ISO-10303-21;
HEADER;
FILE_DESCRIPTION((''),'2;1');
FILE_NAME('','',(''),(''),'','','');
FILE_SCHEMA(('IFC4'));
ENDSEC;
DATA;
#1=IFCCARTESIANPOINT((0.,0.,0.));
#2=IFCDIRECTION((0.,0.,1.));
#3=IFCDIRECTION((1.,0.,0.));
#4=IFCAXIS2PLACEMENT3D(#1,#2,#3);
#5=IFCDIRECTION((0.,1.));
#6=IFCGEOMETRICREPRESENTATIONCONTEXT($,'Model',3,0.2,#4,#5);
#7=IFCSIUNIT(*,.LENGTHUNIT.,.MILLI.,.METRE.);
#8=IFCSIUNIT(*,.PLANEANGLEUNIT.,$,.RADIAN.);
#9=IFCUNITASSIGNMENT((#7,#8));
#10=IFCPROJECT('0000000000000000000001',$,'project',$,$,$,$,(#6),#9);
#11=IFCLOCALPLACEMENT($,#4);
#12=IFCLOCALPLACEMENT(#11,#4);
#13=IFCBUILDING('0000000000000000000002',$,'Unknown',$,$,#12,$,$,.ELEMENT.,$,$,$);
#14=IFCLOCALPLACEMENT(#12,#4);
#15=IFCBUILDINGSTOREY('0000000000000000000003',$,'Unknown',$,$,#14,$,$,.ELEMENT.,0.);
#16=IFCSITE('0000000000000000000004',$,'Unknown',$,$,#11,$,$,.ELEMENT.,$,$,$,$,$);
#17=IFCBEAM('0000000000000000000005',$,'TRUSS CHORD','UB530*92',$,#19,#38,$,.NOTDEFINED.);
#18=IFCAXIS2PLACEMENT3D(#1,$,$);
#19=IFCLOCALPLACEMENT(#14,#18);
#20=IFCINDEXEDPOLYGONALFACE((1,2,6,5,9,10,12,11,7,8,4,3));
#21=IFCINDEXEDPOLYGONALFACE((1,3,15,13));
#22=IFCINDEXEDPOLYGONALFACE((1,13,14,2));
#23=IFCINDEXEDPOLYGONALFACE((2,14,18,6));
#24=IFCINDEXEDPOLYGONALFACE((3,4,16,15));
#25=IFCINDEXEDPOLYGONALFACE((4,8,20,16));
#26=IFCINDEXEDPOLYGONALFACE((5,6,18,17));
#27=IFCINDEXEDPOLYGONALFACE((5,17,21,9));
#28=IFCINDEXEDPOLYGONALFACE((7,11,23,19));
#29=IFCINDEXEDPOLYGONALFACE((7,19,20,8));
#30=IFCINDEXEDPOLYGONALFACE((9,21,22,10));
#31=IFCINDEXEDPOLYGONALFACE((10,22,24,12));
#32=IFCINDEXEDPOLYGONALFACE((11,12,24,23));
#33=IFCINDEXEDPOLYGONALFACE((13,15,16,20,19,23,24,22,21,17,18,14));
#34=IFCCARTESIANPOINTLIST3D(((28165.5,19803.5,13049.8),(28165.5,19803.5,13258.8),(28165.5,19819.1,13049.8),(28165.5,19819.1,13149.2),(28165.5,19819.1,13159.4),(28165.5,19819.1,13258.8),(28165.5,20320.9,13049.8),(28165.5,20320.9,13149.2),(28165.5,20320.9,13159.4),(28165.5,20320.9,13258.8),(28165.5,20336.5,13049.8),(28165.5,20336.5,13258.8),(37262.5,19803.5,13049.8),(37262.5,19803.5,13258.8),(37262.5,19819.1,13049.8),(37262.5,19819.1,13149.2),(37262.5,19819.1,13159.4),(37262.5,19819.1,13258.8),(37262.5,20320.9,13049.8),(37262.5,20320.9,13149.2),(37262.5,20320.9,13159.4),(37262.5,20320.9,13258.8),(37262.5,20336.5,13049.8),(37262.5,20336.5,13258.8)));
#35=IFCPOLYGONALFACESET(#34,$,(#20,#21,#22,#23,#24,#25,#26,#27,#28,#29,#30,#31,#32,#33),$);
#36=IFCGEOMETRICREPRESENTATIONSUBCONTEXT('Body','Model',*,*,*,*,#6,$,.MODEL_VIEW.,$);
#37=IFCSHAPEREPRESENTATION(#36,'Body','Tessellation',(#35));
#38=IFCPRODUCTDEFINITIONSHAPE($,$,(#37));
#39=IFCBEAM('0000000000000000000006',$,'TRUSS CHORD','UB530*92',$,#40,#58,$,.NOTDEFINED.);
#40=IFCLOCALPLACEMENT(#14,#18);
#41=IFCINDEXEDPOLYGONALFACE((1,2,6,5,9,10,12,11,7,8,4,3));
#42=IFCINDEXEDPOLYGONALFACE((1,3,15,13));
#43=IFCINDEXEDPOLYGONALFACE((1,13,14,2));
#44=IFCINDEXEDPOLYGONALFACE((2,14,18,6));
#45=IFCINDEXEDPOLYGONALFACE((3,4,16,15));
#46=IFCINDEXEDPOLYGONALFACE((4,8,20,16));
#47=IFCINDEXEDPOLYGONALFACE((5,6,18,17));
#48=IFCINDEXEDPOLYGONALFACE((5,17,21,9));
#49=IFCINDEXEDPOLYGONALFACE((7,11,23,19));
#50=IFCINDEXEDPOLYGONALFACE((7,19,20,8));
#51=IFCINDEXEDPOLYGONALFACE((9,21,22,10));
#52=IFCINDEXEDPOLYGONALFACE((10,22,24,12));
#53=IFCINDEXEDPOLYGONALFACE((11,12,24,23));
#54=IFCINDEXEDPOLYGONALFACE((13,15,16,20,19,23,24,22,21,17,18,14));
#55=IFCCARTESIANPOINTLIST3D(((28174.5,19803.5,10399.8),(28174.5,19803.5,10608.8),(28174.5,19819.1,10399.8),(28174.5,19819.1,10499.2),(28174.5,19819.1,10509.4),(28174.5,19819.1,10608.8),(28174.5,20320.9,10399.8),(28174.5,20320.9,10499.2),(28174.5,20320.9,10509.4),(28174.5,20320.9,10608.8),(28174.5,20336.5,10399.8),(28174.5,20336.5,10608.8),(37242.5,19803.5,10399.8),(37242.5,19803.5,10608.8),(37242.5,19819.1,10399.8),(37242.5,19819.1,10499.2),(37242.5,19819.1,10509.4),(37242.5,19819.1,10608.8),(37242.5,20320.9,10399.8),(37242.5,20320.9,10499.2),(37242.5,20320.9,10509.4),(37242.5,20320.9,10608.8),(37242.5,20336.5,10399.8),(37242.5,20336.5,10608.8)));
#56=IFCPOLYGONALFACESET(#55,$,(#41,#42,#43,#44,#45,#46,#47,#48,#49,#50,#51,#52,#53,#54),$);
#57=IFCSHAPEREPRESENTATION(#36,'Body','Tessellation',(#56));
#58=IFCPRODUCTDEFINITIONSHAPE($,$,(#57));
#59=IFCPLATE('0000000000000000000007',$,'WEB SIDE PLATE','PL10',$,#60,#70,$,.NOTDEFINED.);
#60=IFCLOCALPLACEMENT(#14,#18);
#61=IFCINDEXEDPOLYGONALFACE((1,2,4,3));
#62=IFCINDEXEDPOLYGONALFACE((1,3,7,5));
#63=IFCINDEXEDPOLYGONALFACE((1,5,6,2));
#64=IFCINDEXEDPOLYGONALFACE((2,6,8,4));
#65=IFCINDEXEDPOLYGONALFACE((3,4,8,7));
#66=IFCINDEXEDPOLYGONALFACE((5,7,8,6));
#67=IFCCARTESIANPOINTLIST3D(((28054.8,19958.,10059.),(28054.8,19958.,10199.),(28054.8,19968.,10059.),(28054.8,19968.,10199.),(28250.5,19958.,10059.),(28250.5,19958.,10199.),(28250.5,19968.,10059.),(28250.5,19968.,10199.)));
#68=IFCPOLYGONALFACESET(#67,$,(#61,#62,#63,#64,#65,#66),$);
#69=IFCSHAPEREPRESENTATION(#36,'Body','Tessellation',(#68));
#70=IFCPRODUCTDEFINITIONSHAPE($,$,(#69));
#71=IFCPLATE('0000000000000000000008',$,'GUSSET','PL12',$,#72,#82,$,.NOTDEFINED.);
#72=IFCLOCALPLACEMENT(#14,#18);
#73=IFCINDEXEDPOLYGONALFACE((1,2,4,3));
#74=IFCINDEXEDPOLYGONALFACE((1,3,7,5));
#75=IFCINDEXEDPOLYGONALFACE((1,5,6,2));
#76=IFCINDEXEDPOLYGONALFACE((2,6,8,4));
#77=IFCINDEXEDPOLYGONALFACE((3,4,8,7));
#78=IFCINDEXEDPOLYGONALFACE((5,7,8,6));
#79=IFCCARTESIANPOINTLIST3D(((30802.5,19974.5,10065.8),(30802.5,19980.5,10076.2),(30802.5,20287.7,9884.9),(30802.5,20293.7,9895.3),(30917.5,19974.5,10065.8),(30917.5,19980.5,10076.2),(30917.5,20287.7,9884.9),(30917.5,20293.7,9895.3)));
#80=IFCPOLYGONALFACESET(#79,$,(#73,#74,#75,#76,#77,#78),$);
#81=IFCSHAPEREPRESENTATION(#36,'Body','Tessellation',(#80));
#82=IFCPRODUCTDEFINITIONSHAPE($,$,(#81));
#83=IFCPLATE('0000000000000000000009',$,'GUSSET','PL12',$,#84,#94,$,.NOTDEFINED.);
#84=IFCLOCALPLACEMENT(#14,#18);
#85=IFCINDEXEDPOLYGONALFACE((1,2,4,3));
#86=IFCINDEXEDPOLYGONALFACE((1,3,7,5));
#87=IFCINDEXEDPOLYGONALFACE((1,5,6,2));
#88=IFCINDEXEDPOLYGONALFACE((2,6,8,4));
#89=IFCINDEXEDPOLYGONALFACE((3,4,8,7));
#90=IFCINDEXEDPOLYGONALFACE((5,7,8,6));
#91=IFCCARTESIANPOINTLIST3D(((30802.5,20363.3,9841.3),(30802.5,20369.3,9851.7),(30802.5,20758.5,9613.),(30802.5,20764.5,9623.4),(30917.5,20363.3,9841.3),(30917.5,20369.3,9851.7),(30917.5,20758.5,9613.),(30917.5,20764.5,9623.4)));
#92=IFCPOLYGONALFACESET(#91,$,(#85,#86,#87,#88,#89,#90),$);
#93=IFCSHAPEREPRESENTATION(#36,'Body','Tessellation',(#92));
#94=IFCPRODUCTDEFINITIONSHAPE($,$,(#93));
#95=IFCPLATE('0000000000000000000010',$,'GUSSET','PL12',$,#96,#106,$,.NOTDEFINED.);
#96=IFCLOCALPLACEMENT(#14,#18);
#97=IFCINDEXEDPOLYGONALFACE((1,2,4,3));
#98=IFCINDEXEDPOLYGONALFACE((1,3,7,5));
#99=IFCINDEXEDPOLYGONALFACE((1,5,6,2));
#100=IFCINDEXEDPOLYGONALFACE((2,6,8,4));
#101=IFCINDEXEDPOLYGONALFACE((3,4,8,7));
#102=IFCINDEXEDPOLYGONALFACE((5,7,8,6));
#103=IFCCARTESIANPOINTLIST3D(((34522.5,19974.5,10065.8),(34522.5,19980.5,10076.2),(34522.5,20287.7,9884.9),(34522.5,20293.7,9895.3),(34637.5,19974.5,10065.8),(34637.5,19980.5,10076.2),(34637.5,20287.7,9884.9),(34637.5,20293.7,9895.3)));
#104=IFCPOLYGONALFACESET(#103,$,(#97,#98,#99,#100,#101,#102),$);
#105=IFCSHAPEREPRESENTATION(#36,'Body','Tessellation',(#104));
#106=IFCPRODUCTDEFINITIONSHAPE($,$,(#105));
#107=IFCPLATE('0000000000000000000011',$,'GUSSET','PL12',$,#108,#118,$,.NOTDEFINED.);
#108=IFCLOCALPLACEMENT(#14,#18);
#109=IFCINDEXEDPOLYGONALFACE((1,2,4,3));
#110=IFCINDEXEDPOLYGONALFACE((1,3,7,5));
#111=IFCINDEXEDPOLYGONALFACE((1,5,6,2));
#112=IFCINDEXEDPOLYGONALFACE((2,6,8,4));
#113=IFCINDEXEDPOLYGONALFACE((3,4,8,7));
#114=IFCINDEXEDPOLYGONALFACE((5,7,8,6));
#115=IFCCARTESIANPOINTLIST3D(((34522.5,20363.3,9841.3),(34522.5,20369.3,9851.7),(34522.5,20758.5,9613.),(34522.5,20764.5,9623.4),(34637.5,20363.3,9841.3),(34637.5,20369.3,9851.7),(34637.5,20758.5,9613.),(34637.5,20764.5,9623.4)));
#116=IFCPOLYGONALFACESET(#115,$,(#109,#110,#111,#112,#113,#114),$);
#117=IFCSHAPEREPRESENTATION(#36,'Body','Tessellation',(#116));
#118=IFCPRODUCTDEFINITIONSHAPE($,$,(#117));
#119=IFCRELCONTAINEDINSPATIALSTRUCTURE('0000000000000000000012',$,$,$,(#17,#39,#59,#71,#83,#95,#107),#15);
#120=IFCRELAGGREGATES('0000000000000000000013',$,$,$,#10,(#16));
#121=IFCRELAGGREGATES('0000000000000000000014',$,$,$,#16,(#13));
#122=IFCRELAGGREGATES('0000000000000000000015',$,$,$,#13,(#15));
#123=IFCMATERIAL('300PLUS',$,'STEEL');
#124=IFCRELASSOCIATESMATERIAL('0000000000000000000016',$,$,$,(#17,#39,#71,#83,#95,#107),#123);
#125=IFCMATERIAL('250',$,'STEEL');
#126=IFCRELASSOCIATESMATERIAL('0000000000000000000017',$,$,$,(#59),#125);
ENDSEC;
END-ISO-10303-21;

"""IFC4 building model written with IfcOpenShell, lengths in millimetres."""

from ifc_helpers import new_model, si_unit, direction, frame, origin_with_axes, place, context, subcontext, project, spatial, line, indexed_curve, outline, extrude, material, element, save


model = new_model("IFC4")

# Units and contexts
model_context = context("Model", 3, precision=0.2, world=origin_with_axes(), true_north=direction((0.0, 1.0)))
body_context = subcontext(model_context, "Body", "Model", "MODEL_VIEW")
ifc_project = project(units=[si_unit("LENGTHUNIT", "METRE", prefix="MILLI"), si_unit("PLANEANGLEUNIT", "RADIAN")], contexts=[model_context])

# Site, building, storey
site_placement = place(None, origin_with_axes())
site = spatial("IfcSite", under=ifc_project, at=site_placement, Name="Unknown", CompositionType="ELEMENT")
building_placement = place(site_placement, origin_with_axes())
building = spatial("IfcBuilding", under=site, at=building_placement, Name="Unknown", CompositionType="ELEMENT")
storey_placement = place(building_placement, origin_with_axes())
storey = spatial("IfcBuildingStorey", under=building, at=storey_placement, Name="Unknown", CompositionType="ELEMENT", Elevation=0.0)

# Shared definitions
ifc_material_1 = material(Name="300PLUS", Category="STEEL")

# Beams
beam_1_placement = place(storey_placement, frame((28165.5, 20070.0, 13154.3), z_axis=(0.0, 0.0, 1.0), x_axis=(1.0, 0.0, 0.0)))
element("IfcBeam", 1, at=beam_1_placement, inside=storey, material=ifc_material_1, Name="TRUSS CHORD", Description="UB530*92", PredefinedType="NOTDEFINED", context=body_context, shape_type="SolidModel", body=[
    extrude(outline(indexed_curve([(-104.5, -266.5), (104.5, -266.5), (104.5, -250.9), (5.1, -250.9), (5.1, 250.9), (104.5, 250.9), (104.5, 266.5), (-104.5, 266.5), (-104.5, 250.9), (-5.1, 250.9), (-5.1, -250.9), (-104.5, -250.9)], segments=[line(1, 2, 3, 4, 5, 6, 7, 8, 9, 10, 11, 12, 1)])), frame((0.0, 0.0, 0.0), z_axis=(-1.0, 0.0, 0.0), x_axis=(0.0, 0.0, 1.0)), (0.0, 0.0, -1.0), 9097.0),
])
beam_2_placement = place(storey_placement, frame((28174.5, 20070.0, 10504.3), z_axis=(0.0, 0.0, 1.0), x_axis=(1.0, 0.0, 0.0)))
element("IfcBeam", 2, at=beam_2_placement, inside=storey, material=ifc_material_1, Name="TRUSS CHORD", Description="UB530*92", PredefinedType="NOTDEFINED", context=body_context, shape_type="SolidModel", body=[
    extrude(outline(indexed_curve([(-104.5, -266.5), (104.5, -266.5), (104.5, -250.9), (5.1, -250.9), (5.1, 250.9), (104.5, 250.9), (104.5, 266.5), (-104.5, 266.5), (-104.5, 250.9), (-5.1, 250.9), (-5.1, -250.9), (-104.5, -250.9)], segments=[line(1, 2, 3, 4, 5, 6, 7, 8, 9, 10, 11, 12, 1)])), frame((0.0, 0.0, 0.0), z_axis=(-1.0, 0.0, 0.0), x_axis=(0.0, 0.0, 1.0)), (0.0, 0.0, -1.0), 9068.0),
])

# Plates
ifc_material_2 = material(Name="250", Category="STEEL")
plate_1_placement = place(storey_placement, frame((28250.5, 19963.0, 10059.0), z_axis=(0.0, -1.0, 0.0), x_axis=(0.0, 0.0, 1.0)))
element("IfcPlate", 3, at=plate_1_placement, inside=storey, material=ifc_material_2, Name="WEB SIDE PLATE", Description="PL10", PredefinedType="NOTDEFINED", context=body_context, shape_type="SolidModel", body=[
    extrude(outline(indexed_curve([(0.0, 0.0), (140.0, 0.0), (140.0, 195.7), (0.0, 195.7)], segments=[line(1, 2, 3, 4, 1)])), frame((0.0, 0.0, 5.0), z_axis=(0.0, 0.0, 1.0), x_axis=(1.0, 0.0, 0.0)), (0.0, 0.0, -1.0), 10.0),
])
plate_2_placement = place(storey_placement, frame((30917.5, 19977.5, 10071.0), z_axis=(0.0, 0.500153, 0.865937), x_axis=(0.0, 0.865937, -0.500153)))
element("IfcPlate", 4, at=plate_2_placement, inside=storey, material=ifc_material_1, Name="GUSSET", Description="PL12", PredefinedType="NOTDEFINED", context=body_context, shape_type="SolidModel", body=[
    extrude(outline(indexed_curve([(0.0, 0.0), (361.7, 0.0), (361.7, 115.0), (0.0, 115.0)], segments=[line(1, 2, 3, 4, 1)])), frame((0.0, 0.0, 6.0), z_axis=(0.0, 0.0, 1.0), x_axis=(1.0, 0.0, 0.0)), (0.0, 0.0, -1.0), 12.0),
])
plate_3_placement = place(storey_placement, frame((30802.5, 20761.5, 9618.2), z_axis=(0.0, 0.500216, 0.865901), x_axis=(0.0, -0.865901, 0.500216)))
element("IfcPlate", 5, at=plate_3_placement, inside=storey, material=ifc_material_1, Name="GUSSET", Description="PL12", PredefinedType="NOTDEFINED", context=body_context, shape_type="SolidModel", body=[
    extrude(outline(indexed_curve([(0.0, 0.0), (456.4, 0.0), (456.4, 115.0), (0.0, 115.0)], segments=[line(1, 2, 3, 4, 1)])), frame((0.0, 0.0, 6.0), z_axis=(0.0, 0.0, 1.0), x_axis=(1.0, 0.0, 0.0)), (0.0, 0.0, -1.0), 12.0),
])
plate_4_placement = place(storey_placement, frame((34637.5, 19977.5, 10071.0), z_axis=(0.0, 0.500153, 0.865937), x_axis=(0.0, 0.865937, -0.500153)))
element("IfcPlate", 6, at=plate_4_placement, inside=storey, material=ifc_material_1, Name="GUSSET", Description="PL12", PredefinedType="NOTDEFINED", context=body_context, shape_type="SolidModel", body=[
    extrude(outline(indexed_curve([(0.0, 0.0), (361.7, 0.0), (361.7, 115.0), (0.0, 115.0)], segments=[line(1, 2, 3, 4, 1)])), frame((0.0, 0.0, 6.0), z_axis=(0.0, 0.0, 1.0), x_axis=(1.0, 0.0, 0.0)), (0.0, 0.0, -1.0), 12.0),
])
plate_5_placement = place(storey_placement, frame((34522.5, 20761.5, 9618.2), z_axis=(0.0, 0.500216, 0.865901), x_axis=(0.0, -0.865901, 0.500216)))
element("IfcPlate", 7, at=plate_5_placement, inside=storey, material=ifc_material_1, Name="GUSSET", Description="PL12", PredefinedType="NOTDEFINED", context=body_context, shape_type="SolidModel", body=[
    extrude(outline(indexed_curve([(0.0, 0.0), (456.4, 0.0), (456.4, 115.0), (0.0, 115.0)], segments=[line(1, 2, 3, 4, 1)])), frame((0.0, 0.0, 6.0), z_axis=(0.0, 0.0, 1.0), x_axis=(1.0, 0.0, 0.0)), (0.0, 0.0, -1.0), 12.0),
])

save(model, "model.ifc")
